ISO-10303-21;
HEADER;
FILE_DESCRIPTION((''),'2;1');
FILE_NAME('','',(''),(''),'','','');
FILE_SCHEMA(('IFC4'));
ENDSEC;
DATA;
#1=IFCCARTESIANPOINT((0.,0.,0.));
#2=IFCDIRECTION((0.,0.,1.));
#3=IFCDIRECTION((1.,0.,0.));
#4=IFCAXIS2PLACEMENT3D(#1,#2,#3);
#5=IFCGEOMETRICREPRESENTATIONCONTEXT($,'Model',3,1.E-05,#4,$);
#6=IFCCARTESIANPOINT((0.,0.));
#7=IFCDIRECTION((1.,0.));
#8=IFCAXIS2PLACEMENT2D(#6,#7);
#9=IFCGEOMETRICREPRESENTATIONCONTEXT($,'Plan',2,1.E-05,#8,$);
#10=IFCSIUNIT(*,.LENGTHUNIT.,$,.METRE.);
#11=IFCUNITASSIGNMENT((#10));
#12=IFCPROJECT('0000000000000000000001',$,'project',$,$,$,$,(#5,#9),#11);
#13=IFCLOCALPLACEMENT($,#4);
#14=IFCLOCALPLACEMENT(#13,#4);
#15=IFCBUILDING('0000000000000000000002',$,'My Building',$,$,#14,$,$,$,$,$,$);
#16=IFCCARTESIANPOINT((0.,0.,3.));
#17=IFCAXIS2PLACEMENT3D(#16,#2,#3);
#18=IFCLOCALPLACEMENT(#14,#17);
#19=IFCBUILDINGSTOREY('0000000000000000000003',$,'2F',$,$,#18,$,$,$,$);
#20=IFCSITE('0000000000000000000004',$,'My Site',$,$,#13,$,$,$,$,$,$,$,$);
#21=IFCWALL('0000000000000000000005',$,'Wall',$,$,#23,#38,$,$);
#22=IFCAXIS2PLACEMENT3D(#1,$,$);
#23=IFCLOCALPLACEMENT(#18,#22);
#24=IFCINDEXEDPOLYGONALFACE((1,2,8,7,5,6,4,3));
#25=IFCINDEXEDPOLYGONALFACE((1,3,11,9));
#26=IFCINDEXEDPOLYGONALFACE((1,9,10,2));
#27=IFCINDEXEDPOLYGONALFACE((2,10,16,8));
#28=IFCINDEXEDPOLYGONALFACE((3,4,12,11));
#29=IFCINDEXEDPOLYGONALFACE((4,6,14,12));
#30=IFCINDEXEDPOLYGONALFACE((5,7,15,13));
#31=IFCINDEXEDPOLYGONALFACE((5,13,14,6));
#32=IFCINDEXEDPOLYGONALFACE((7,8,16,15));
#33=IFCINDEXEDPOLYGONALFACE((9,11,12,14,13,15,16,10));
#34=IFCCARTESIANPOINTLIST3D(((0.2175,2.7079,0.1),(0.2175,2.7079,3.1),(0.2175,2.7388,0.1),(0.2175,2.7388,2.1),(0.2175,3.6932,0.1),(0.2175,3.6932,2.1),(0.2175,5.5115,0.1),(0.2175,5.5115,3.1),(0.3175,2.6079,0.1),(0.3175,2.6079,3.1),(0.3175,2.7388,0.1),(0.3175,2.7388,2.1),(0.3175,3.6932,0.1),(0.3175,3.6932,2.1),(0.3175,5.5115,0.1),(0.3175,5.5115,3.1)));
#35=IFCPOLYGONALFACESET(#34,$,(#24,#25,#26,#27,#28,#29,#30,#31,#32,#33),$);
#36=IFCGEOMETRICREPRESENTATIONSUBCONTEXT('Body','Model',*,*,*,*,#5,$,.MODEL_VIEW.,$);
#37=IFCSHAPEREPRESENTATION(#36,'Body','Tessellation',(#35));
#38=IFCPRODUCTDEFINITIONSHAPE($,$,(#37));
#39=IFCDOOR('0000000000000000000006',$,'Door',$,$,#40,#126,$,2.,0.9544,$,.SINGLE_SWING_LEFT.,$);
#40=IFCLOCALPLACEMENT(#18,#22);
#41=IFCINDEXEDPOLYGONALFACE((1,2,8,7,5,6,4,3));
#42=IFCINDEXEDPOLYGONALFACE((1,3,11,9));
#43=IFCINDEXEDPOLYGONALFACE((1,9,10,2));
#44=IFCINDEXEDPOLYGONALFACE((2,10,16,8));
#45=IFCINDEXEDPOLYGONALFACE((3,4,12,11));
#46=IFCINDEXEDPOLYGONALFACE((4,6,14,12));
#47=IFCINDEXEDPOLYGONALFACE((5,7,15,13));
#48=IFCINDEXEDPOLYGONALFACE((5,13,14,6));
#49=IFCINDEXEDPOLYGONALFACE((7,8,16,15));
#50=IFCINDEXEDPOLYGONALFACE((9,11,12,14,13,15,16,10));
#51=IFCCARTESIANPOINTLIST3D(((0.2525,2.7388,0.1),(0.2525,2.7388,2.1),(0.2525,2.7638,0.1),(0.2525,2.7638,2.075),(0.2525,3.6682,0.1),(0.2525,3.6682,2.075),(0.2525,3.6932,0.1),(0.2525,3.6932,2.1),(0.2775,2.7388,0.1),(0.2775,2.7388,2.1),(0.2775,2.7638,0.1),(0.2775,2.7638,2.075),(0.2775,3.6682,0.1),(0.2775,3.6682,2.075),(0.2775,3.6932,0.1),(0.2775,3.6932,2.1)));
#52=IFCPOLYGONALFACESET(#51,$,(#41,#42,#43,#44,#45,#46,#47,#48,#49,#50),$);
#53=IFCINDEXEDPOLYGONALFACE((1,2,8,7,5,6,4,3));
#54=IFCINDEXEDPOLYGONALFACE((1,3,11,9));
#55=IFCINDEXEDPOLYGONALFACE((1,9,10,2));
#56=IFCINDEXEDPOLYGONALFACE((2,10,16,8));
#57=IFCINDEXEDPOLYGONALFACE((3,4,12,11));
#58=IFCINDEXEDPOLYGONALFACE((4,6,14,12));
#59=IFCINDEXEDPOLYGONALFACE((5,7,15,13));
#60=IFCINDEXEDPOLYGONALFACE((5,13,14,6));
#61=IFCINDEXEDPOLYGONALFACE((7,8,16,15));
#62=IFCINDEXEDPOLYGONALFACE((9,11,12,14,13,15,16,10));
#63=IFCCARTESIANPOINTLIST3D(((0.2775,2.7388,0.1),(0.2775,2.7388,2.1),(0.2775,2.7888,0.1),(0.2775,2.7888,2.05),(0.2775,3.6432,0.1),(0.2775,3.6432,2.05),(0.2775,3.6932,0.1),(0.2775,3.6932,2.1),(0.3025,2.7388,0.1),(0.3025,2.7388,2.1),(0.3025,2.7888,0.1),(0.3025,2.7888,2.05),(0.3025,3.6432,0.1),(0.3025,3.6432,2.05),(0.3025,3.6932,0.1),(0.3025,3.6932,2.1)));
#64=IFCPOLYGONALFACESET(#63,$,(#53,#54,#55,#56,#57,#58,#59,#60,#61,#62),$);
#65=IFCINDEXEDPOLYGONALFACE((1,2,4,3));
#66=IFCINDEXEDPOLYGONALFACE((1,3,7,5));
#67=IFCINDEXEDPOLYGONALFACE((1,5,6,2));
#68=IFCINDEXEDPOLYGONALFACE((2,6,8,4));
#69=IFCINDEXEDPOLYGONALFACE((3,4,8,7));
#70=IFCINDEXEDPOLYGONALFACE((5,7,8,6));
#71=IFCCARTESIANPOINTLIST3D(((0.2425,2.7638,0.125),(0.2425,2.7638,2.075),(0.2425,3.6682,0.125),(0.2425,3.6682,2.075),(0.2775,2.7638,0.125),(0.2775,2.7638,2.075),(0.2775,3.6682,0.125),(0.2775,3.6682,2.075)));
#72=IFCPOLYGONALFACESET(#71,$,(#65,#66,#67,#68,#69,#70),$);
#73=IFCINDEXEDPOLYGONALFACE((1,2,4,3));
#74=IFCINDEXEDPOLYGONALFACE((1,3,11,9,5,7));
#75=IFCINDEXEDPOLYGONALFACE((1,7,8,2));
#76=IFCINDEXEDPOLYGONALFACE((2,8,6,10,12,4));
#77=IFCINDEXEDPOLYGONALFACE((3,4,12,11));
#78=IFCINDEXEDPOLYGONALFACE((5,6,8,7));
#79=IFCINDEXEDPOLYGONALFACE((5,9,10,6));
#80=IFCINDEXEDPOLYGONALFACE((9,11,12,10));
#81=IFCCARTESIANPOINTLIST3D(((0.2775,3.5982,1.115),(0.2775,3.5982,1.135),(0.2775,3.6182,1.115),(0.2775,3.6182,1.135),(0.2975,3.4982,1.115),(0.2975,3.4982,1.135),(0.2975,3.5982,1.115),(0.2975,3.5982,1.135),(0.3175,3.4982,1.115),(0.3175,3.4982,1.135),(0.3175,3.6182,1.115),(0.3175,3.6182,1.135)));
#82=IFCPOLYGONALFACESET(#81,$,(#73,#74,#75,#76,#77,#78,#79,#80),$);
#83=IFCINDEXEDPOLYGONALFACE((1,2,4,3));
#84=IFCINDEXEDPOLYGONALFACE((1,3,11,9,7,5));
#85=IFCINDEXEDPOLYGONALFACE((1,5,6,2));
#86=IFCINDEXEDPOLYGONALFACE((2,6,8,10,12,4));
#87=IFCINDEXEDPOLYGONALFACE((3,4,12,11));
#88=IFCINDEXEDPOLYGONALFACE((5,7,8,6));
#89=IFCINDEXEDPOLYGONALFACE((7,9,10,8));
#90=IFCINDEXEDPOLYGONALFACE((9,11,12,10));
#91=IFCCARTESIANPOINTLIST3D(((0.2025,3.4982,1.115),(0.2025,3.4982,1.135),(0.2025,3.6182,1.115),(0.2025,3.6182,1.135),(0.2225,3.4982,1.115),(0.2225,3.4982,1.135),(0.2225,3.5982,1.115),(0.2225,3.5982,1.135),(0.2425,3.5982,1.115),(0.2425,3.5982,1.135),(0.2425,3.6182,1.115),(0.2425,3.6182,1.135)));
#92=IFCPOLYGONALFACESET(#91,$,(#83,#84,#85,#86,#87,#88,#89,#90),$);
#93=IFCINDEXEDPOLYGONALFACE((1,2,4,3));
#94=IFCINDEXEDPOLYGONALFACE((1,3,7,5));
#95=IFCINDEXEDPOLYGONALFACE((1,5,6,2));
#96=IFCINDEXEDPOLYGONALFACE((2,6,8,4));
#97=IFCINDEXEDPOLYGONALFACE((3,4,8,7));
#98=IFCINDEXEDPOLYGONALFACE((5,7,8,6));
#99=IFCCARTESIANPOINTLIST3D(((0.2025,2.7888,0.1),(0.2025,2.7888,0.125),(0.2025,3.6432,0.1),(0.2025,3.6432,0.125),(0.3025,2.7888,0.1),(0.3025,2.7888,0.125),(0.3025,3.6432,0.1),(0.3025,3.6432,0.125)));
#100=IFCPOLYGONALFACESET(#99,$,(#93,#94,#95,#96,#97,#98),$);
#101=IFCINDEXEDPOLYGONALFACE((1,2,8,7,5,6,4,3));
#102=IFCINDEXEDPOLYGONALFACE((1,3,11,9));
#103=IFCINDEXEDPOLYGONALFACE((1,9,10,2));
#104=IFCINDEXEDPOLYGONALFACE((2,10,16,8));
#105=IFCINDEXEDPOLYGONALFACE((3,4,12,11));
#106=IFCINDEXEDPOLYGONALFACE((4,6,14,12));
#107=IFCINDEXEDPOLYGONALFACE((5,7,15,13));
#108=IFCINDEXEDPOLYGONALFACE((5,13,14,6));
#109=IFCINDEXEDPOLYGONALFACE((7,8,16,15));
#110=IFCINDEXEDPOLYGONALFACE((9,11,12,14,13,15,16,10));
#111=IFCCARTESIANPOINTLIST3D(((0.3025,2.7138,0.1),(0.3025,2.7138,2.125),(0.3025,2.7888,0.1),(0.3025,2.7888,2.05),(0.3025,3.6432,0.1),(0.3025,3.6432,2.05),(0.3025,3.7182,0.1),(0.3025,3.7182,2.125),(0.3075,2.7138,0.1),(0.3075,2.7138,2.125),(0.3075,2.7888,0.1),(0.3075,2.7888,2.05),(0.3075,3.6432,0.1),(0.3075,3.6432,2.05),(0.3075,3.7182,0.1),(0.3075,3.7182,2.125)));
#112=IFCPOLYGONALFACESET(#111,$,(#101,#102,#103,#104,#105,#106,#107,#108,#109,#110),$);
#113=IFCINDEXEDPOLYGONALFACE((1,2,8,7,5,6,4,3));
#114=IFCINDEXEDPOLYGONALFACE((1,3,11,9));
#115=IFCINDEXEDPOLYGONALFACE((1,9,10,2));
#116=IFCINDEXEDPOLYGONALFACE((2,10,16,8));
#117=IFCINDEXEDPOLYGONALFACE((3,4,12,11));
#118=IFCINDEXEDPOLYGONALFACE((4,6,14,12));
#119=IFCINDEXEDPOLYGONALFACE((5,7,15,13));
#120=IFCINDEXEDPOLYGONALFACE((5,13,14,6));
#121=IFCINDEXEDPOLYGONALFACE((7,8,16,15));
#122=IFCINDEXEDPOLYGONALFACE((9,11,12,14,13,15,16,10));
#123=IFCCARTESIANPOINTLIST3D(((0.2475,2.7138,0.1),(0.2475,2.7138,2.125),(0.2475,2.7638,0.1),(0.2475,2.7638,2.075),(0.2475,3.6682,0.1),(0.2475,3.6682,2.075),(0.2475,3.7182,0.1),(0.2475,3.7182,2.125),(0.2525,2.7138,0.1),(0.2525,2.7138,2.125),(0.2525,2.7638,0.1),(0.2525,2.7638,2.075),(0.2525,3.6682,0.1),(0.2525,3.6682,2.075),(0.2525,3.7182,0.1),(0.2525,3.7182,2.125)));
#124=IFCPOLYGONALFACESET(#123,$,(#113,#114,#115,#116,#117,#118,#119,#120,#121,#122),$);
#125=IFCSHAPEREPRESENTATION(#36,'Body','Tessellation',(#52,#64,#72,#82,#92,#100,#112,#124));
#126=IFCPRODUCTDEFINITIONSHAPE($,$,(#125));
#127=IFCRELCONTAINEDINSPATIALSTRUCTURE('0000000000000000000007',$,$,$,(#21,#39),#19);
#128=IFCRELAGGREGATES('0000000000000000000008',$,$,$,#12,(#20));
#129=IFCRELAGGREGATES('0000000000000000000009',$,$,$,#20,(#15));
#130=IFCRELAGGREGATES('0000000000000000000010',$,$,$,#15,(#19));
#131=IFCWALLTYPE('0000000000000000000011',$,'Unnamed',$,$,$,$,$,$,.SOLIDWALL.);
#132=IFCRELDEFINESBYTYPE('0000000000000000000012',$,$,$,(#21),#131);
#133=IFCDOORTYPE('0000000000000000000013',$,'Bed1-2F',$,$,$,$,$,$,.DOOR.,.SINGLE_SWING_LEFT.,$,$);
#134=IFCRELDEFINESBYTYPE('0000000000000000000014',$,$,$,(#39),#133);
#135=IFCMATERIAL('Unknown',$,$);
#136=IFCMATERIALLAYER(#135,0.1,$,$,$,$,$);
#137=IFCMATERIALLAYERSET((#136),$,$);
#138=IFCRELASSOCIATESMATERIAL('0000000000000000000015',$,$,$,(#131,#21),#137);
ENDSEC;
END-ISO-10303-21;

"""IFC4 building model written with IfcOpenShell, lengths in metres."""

from ifc_helpers import new_model, entity, si_unit, frame, origin_with_axes, origin_2d_with_axis, place, context, subcontext, project, spatial, line, indexed_curve, outline, extrude, shape, source, transform, mapped, material, layer, layer_set, layer_usage, type_object, type_shapes, element, fill, save


model = new_model("IFC4")

# Units and contexts
model_context = context("Model", 3, precision=1e-05, world=origin_with_axes())
plan_context = context("Plan", 2, precision=1e-05, world=origin_2d_with_axis())
body_context_1 = subcontext(model_context, "Body", "Model", "MODEL_VIEW")
body_context_2 = subcontext(plan_context, "Body", "Plan", "PLAN_VIEW")
ifc_project = project(units=[si_unit("LENGTHUNIT", "METRE")], contexts=[model_context, plan_context])

# Site, building, storey
site_placement = place(None, origin_with_axes())
site = spatial("IfcSite", under=ifc_project, at=site_placement, Name="My Site")
building_placement = place(site_placement, origin_with_axes())
building = spatial("IfcBuilding", under=site, at=building_placement, Name="My Building")
storey_placement = place(building_placement, frame((0.0, 0.0, 3.0), z_axis=(0.0, 0.0, 1.0), x_axis=(1.0, 0.0, 0.0)))
storey = spatial("IfcBuildingStorey", under=building, at=storey_placement, Name="2F")

# Shared definitions
ifc_material = material(Name="Unknown")
ifc_layer = layer(ifc_material, 0.1)
ifc_layer_set = layer_set([ifc_layer])
wall_type = type_object("IfcWallType", Name="Unnamed", PredefinedType="SOLIDWALL", material=ifc_layer_set)

# Wall, opening, door
ifc_layer_usage_1 = layer_usage(ifc_layer_set, "AXIS2", "POSITIVE", 0.0)
wall_1_placement = place(storey_placement, frame((0.3175, 2.7079, 0.1), z_axis=(0.0, 0.0, 1.0), x_axis=(0.0, 1.0, 0.0)))
wall_1 = element("IfcWall", 1, at=wall_1_placement, inside=storey, type_object=wall_type, material=ifc_layer_usage_1, Name="Wall", context=body_context_1, shape_type="SweptSolid", body=[
    extrude(outline(indexed_curve([(-0.1, 0.0), (0.0, 0.1), (2.8037, 0.1), (2.8037, 0.0)], segments=[line(1, 2, 3, 4, 1)])), origin_with_axes(), (0.0, 0.0, 1.0), 3.0),
])
shared_shape_1 = source(origin_with_axes(), body_context_1, "Body", "SweptSolid", [
    extrude(outline(indexed_curve([(0.0, 0.0), (0.9544, 0.0), (0.9544, 2.0), (0.0, 2.0)], segments=[line(1, 2, 3, 4, 1)])), frame((0.0, -0.6, 0.0), z_axis=(0.0, -1.0, 0.0), x_axis=(1.0, 0.0, 0.0)), (0.0, 0.0, -1.0), 1.2),
])
opening_1_placement = place(wall_1_placement, frame((0.0309, 0.015, 0.0), z_axis=(0.0, 0.0, 1.0), x_axis=(1.0, 0.0, 0.0)))
opening_1 = element("IfcOpeningElement", 2, at=opening_1_placement, cuts=wall_1, PredefinedType="OPENING", context=body_context_1, shape_type="MappedRepresentation", body=[
    mapped(shared_shape_1, transform((0.0, 0.0, 0.0), x_axis=(1.0, 0.0, 0.0), y_axis=(0.0, 1.0, 0.0), z_axis=(0.0, 0.0, 1.0), scale=1.0)),
])
door_type_1 = type_object("IfcDoorType", Name="Bed1-2F", OperationType="SINGLE_SWING_LEFT", PredefinedType="DOOR")
shared_shape_2 = source(origin_with_axes(), body_context_1, "Body", "SweptSolid", [
    extrude(outline(indexed_curve([(0.0, 0.0), (0.0, 2.0), (0.9544, 2.0), (0.9544, 0.0), (0.9294, 0.0), (0.9294, 1.975), (0.025, 1.975), (0.025, 0.0)], segments=[line(1, 2, 3, 4, 5, 6, 7, 8, 1)])), frame((0.0, 0.025, 0.0), z_axis=(0.0, -1.0, 0.0), x_axis=(1.0, 0.0, 0.0)), (0.0, 0.0, -1.0), 0.025),
    extrude(outline(indexed_curve([(0.0, 0.0), (0.0, 2.0), (0.9544, 2.0), (0.9544, 0.0), (0.9044, 0.0), (0.9044, 1.95), (0.05, 1.95), (0.05, 0.0)], segments=[line(1, 2, 3, 4, 5, 6, 7, 8, 1)])), frame((0.0, 0.0, 0.0), z_axis=(0.0, -1.0, 0.0), x_axis=(1.0, 0.0, 0.0)), (0.0, 0.0, -1.0), 0.025),
    extrude(outline(indexed_curve([(0.0, 0.0), (0.9044, 0.0), (0.9044, 0.035), (0.0, 0.035)], segments=[line(1, 2, 3, 4, 1)])), frame((0.025, 0.025, 0.025), z_axis=(0.0, 0.0, 1.0), x_axis=(1.0, 0.0, 0.0)), (0.0, 0.0, 1.0), 1.95),
    extrude(outline(indexed_curve([(0.0, 0.0), (0.0, -0.04), (-0.12, -0.04), (-0.12, -0.02), (-0.02, -0.02), (-0.02, 0.0)], segments=[line(1, 2, 3, 4, 5, 6, 1)])), frame((0.8794, 0.025, 1.015), z_axis=(0.0, 0.0, 1.0), x_axis=(1.0, 0.0, 0.0)), (0.0, 0.0, 1.0), 0.02),
    extrude(outline(indexed_curve([(0.0, 0.0), (0.0, 0.04), (-0.12, 0.04), (-0.12, 0.02), (-0.02, 0.02), (-0.02, 0.0)], segments=[line(1, 2, 3, 4, 5, 6, 1)])), frame((0.8794, 0.06, 1.015), z_axis=(0.0, 0.0, 1.0), x_axis=(1.0, 0.0, 0.0)), (0.0, 0.0, 1.0), 0.02),
    extrude(outline(indexed_curve([(0.0, 0.0), (0.8544, 0.0), (0.8544, 0.1), (0.0, 0.1)], segments=[line(1, 2, 3, 4, 1)])), frame((0.05, 0.0, 0.0), z_axis=(0.0, 0.0, 1.0), x_axis=(1.0, 0.0, 0.0)), (0.0, 0.0, 1.0), 0.025),
    extrude(outline(indexed_curve([(0.0, 0.0), (0.0, 2.025), (1.0044, 2.025), (1.0044, 0.0), (0.9294, 0.0), (0.9294, 1.95), (0.075, 1.95), (0.075, 0.0)], segments=[line(1, 2, 3, 4, 5, 6, 7, 8, 1)])), frame((-0.025, -0.005, 0.0), z_axis=(0.0, -1.0, 0.0), x_axis=(1.0, 0.0, 0.0)), (0.0, 0.0, -1.0), 0.005),
    extrude(outline(indexed_curve([(0.0, 0.0), (0.0, 2.025), (1.0044, 2.025), (1.0044, 0.0), (0.9544, 0.0), (0.9544, 1.975), (0.05, 1.975), (0.05, 0.0)], segments=[line(1, 2, 3, 4, 5, 6, 7, 8, 1)])), frame((-0.025, 0.05, 0.0), z_axis=(0.0, -1.0, 0.0), x_axis=(1.0, 0.0, 0.0)), (0.0, 0.0, -1.0), 0.005),
])
shared_shape_3 = source(origin_with_axes(), body_context_2, "Body", "Curve2D", [
    entity("IfcIndexedPolyCurve", entity("IfcCartesianPointList2D", [[0.0, 0.0], [0.0, 0.05], [0.025, 0.05], [0.025, 0.025], [0.05, 0.025], [0.05, 0.0]]), [entity("IfcLineIndex", [1, 2, 3, 4, 5, 6, 1])]),
    entity("IfcIndexedPolyCurve", entity("IfcCartesianPointList2D", [[0.9544, 0.0], [0.9544, 0.05], [0.9294, 0.05], [0.9294, 0.025], [0.9044, 0.025], [0.9044, 0.0]]), [entity("IfcLineIndex", [1, 2, 3, 4, 5, 6, 1])]),
    entity("IfcTrimmedCurve", entity("IfcEllipse", entity("IfcAxis2Placement2D", entity("IfcCartesianPoint", [0.06, 0.05]), entity("IfcDirection", [1.0, 0.0])), 0.8694, 0.9044), [entity("IfcCartesianPoint", [0.9294, 0.05])], [entity("IfcCartesianPoint", [0.06, 0.9544])], True, "CARTESIAN"),
    entity("IfcIndexedPolyCurve", entity("IfcCartesianPointList2D", [[0.025, 0.05], [0.06, 0.05], [0.06, 0.9544], [0.025, 0.9544]]), [entity("IfcLineIndex", [1, 2, 3, 4, 1])]),
])
type_shapes(door_type_1, [shared_shape_2, shared_shape_3])
door_1_placement = place(opening_1_placement, frame((0.0, 0.0, 0.0), z_axis=(0.0, 0.0, 1.0), x_axis=(1.0, 0.0, 0.0)))
door_1 = element("IfcDoor", 3, at=door_1_placement, inside=storey, type_object=door_type_1, Name="Door", OperationType="SINGLE_SWING_LEFT", OverallHeight=2.0, OverallWidth=0.9544, shapes=[
    shape(body_context_1, "Body", "MappedRepresentation", [mapped(shared_shape_2, transform((0.0, 0.0, 0.0), x_axis=(1.0, 0.0, 0.0), y_axis=(0.0, 1.0, 0.0), z_axis=(0.0, 0.0, 1.0), scale=1.0))]),
    shape(body_context_2, "Body", "MappedRepresentation", [mapped(shared_shape_3, transform((0.0, 0.0, 0.0), x_axis=(1.0, 0.0, 0.0), y_axis=(0.0, 1.0, 0.0), z_axis=(0.0, 0.0, 1.0), scale=1.0))]),
])
fill(opening_1, door_1)

save(model, "model.ifc")
